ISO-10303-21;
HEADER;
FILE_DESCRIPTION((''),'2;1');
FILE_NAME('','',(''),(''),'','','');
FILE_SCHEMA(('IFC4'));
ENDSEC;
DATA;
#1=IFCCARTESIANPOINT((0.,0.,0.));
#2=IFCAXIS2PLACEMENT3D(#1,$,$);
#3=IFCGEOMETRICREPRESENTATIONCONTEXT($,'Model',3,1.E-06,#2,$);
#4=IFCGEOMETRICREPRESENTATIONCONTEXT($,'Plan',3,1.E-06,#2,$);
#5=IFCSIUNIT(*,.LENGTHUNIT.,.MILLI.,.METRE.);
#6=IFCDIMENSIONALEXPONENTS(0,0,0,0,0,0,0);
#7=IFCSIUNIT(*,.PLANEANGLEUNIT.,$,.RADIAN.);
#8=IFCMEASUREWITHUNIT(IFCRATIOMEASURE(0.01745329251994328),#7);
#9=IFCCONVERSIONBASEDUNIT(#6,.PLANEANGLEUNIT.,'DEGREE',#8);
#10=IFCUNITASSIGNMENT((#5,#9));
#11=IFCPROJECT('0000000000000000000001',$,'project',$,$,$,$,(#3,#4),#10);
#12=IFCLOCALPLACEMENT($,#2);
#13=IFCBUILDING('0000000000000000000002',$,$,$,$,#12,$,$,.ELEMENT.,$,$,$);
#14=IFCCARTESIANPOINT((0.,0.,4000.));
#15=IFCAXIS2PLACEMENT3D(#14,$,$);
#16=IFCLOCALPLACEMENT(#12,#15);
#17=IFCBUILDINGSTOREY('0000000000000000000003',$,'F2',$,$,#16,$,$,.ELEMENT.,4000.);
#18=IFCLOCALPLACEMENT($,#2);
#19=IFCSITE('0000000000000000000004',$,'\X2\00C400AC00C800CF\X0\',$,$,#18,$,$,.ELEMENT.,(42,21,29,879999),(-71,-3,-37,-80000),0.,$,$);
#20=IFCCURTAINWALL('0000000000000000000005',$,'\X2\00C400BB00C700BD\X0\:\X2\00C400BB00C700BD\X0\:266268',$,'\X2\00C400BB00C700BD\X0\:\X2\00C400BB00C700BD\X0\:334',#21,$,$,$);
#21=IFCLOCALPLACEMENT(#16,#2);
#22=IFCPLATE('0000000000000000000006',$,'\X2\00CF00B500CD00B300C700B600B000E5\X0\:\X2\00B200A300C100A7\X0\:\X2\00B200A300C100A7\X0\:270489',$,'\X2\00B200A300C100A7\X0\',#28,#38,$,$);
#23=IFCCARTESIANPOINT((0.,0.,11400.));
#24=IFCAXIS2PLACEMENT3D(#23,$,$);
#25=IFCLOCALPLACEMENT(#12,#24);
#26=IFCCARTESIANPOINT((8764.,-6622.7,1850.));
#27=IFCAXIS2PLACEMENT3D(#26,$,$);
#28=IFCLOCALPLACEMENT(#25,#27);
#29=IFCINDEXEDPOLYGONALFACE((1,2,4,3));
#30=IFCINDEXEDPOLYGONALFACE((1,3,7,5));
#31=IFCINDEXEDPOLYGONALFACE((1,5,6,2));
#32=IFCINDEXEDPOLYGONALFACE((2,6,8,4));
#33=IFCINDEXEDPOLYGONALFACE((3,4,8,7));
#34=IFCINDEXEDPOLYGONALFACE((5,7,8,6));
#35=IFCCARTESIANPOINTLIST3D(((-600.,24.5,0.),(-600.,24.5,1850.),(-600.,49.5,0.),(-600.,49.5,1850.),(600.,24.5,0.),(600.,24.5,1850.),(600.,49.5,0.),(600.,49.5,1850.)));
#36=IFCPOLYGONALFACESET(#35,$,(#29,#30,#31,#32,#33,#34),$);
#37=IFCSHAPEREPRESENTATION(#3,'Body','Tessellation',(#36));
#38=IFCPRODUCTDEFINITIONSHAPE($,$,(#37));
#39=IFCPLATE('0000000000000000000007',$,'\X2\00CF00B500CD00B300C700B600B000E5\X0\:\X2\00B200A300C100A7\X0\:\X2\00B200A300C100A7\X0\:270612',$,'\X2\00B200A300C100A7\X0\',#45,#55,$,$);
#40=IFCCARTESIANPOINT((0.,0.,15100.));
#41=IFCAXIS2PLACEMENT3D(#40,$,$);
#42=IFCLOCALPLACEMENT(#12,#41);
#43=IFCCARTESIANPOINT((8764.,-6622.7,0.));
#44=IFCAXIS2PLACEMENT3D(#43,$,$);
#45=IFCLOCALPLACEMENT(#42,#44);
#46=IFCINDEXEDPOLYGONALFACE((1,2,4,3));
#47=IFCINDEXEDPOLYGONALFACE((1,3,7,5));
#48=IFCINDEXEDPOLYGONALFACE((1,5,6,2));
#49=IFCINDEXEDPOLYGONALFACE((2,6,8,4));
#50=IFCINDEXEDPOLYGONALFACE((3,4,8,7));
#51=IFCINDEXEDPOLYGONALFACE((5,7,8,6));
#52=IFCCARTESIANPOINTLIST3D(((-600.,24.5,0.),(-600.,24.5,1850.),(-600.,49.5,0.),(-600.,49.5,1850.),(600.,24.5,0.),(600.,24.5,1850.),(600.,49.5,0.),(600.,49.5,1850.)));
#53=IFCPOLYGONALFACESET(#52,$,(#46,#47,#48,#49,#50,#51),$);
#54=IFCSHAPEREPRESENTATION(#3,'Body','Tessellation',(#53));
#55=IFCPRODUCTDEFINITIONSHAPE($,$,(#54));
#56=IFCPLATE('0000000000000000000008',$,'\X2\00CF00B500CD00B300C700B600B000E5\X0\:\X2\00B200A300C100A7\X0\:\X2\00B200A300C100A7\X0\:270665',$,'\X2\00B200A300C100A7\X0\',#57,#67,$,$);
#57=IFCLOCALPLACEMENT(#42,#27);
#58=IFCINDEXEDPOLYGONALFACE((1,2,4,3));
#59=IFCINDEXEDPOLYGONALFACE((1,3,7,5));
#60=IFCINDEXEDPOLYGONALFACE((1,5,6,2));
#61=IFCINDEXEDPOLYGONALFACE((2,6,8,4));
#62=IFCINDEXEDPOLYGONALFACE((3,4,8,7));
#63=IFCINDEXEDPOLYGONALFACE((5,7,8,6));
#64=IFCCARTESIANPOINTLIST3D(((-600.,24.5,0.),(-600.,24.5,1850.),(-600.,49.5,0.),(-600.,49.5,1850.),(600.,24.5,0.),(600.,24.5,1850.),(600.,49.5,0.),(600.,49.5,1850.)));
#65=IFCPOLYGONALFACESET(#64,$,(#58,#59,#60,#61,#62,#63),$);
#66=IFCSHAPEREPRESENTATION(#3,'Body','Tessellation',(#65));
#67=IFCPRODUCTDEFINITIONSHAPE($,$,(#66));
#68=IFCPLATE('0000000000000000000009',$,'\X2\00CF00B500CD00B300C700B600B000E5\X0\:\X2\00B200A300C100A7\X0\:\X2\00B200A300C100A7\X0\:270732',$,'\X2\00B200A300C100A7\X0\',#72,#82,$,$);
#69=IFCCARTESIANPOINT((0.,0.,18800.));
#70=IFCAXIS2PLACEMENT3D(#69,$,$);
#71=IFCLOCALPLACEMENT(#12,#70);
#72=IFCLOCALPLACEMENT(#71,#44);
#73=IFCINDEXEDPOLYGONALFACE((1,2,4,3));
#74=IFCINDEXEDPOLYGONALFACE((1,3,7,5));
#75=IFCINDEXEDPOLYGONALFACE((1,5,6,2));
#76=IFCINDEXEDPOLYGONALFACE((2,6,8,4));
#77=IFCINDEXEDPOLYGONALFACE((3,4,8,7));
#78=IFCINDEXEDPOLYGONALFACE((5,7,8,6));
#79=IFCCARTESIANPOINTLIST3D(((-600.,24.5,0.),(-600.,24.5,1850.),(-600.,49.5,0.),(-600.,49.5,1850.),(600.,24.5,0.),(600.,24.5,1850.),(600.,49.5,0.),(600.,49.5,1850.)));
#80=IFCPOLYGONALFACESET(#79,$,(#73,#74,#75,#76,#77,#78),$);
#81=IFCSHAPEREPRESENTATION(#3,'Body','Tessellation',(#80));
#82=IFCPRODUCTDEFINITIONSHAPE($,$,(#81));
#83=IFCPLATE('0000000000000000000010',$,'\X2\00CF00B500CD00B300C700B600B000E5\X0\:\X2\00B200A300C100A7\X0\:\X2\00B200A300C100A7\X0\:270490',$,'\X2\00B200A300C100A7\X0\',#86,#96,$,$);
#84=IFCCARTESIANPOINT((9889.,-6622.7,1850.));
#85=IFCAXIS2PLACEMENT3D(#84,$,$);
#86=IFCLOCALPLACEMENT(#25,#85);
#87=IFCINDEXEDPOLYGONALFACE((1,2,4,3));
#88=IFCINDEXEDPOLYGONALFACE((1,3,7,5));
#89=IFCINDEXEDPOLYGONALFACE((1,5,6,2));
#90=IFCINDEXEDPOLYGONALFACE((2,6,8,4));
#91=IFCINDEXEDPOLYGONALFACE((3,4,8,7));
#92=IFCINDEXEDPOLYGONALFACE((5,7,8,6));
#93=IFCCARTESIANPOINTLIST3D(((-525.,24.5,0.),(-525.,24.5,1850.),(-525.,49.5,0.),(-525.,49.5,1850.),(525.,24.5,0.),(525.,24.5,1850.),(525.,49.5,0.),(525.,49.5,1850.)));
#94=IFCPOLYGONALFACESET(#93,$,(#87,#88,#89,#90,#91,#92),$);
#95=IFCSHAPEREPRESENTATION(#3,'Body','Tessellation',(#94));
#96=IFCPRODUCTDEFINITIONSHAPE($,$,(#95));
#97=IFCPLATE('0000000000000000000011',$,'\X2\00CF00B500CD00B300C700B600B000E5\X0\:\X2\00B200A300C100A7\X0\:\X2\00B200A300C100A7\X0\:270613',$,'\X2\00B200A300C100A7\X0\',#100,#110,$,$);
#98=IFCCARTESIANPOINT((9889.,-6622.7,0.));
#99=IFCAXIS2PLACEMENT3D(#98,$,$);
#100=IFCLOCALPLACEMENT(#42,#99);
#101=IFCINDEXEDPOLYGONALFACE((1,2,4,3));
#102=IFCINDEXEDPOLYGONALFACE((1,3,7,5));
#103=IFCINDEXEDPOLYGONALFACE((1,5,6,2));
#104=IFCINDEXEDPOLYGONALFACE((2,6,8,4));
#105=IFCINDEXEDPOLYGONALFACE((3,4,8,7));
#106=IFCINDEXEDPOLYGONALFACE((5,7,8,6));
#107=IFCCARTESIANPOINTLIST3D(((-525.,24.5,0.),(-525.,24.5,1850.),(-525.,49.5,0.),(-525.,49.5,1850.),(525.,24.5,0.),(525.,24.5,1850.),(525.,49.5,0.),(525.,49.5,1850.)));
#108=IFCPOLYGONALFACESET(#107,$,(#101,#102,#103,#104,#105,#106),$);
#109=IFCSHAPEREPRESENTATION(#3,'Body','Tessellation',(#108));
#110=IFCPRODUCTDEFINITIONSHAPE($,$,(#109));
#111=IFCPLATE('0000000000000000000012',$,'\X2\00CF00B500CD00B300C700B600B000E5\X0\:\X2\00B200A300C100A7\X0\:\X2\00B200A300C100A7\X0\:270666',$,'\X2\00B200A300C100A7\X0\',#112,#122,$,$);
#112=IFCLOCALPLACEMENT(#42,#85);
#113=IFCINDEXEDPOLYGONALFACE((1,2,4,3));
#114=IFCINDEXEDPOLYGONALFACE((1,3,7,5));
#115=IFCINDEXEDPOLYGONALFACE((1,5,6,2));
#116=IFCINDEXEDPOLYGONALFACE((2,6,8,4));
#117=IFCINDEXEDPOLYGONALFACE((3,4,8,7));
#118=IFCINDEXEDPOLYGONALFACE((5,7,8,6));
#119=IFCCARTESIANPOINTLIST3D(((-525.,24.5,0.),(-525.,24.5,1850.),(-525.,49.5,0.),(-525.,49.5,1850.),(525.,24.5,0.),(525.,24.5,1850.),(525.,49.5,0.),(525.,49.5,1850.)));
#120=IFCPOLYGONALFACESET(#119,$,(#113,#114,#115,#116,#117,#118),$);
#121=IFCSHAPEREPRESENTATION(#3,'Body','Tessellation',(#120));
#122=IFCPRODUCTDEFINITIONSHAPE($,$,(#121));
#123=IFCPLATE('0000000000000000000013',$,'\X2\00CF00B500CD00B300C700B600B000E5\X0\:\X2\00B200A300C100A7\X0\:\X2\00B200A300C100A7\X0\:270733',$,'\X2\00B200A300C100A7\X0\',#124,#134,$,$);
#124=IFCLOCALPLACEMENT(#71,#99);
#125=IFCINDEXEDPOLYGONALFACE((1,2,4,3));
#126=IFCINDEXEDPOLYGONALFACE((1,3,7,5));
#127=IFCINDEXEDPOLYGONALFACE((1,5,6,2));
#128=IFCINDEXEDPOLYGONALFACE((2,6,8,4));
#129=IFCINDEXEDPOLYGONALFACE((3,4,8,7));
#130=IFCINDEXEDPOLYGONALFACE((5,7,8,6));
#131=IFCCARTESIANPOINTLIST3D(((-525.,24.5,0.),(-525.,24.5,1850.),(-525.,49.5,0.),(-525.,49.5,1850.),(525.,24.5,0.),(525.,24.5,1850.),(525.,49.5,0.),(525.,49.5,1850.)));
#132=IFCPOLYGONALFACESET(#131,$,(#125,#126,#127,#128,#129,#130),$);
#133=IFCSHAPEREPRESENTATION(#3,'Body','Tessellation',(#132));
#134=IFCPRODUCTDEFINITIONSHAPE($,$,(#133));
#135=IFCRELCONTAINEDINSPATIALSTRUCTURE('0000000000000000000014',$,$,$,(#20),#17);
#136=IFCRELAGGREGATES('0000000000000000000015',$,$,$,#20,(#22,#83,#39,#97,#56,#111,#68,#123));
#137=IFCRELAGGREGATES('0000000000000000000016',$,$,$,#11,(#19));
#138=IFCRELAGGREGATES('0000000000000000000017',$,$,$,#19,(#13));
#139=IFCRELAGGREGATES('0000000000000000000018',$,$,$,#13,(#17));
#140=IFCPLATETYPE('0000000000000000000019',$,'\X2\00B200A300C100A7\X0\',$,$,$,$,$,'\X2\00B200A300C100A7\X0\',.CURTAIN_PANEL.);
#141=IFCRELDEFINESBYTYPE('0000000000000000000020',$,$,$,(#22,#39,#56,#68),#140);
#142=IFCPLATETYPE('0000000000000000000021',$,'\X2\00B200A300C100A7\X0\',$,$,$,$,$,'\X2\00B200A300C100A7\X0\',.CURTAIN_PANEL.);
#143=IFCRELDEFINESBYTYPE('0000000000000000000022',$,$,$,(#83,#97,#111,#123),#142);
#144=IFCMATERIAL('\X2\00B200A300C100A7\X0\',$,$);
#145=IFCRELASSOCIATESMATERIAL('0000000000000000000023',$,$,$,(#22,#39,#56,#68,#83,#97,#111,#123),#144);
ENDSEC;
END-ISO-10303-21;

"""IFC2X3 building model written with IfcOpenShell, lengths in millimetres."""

from ifc_helpers import new_model, entity, si_unit, converted_unit, frame, origin, origin_2d_with_axis, place, context, project, spatial, rectangle, extrude, source, transform, mapped, material, type_object, type_shapes, element, aggregate, save


model = new_model("IFC2X3")

# Units and contexts
model_context = context("Model", 3, precision=1e-06, world=origin())
plan_context = context("Plan", 3, precision=1e-06, world=origin())
ifc_project = project(units=[si_unit("LENGTHUNIT", "METRE", prefix="MILLI"), converted_unit("PLANEANGLEUNIT", "DEGREE", entity("IfcRatioMeasure", 0.01745329251994328), si_unit("PLANEANGLEUNIT", "RADIAN"), dimensions=[0, 0, 0, 0, 0, 0, 0])], contexts=[model_context, plan_context])

# Site, building, storey
site_placement = place(None, origin())
site = spatial("IfcSite", under=ifc_project, at=site_placement, Name="Ä¬ÈÏ", CompositionType="ELEMENT", RefLatitude=(42, 21, 29, 879999), RefLongitude=(-71, -3, -37, -80000), RefElevation=0.0)
building_placement = place(None, origin())
building = spatial("IfcBuilding", under=site, at=building_placement, CompositionType="ELEMENT")
storey_placement = place(building_placement, frame((0.0, 0.0, 4000.0)))
storey = spatial("IfcBuildingStorey", under=building, at=storey_placement, Name="F2", CompositionType="ELEMENT", Elevation=4000.0)

# Curtain wall, plates
curtain_wall_placement = place(storey_placement, origin())
curtain_wall = element("IfcCurtainWall", 1, at=curtain_wall_placement, inside=storey, Name="Ä»Ç½:Ä»Ç½:266268", ObjectType="Ä»Ç½:Ä»Ç½:334")
placement_1 = place(building_placement, frame((0.0, 0.0, 15100.0)))
placement_2 = place(building_placement, frame((0.0, 0.0, 11400.0)))
placement_3 = place(building_placement, frame((0.0, 0.0, 18800.0)))
ifc_material_1 = material(Name="²£Á§")
plate_type_1 = type_object("IfcPlateType", Name="²£Á§", ElementType="²£Á§", PredefinedType="CURTAIN_PANEL")
shared_shape_1 = source(origin(), model_context, "Body", "SweptSolid", [
    extrude(rectangle(XDim=25.0, YDim=1200.0, at=origin_2d_with_axis()), frame((0.0, 37.0, 0.0), z_axis=(0.0, 0.0, 1.0), x_axis=(0.0, 1.0, 0.0)), (0.0, 0.0, 1.0), 1850.0),
])
type_shapes(plate_type_1, [shared_shape_1])
plate_1_placement = place(placement_2, frame((8764.0, -6622.7, 1850.0)))
plate_1 = element("IfcPlate", 2, at=plate_1_placement, type_object=plate_type_1, material=ifc_material_1, Name="ÏµÍ³Ç¶°å:²£Á§:²£Á§:270489", ObjectType="²£Á§", context=model_context, shape_type="MappedRepresentation", body=[
    mapped(shared_shape_1, transform((0.0, 0.0, 0.0), scale=1.0)),
])
plate_2_placement = place(placement_1, frame((8764.0, -6622.7, 0.0)))
plate_2 = element("IfcPlate", 3, at=plate_2_placement, type_object=plate_type_1, material=ifc_material_1, Name="ÏµÍ³Ç¶°å:²£Á§:²£Á§:270612", ObjectType="²£Á§", context=model_context, shape_type="MappedRepresentation", body=[
    mapped(shared_shape_1, transform((0.0, 0.0, 0.0), scale=1.0)),
])
plate_3_placement = place(placement_1, frame((8764.0, -6622.7, 1850.0)))
plate_3 = element("IfcPlate", 4, at=plate_3_placement, type_object=plate_type_1, material=ifc_material_1, Name="ÏµÍ³Ç¶°å:²£Á§:²£Á§:270665", ObjectType="²£Á§", context=model_context, shape_type="MappedRepresentation", body=[
    mapped(shared_shape_1, transform((0.0, 0.0, 0.0), scale=1.0)),
])
plate_4_placement = place(placement_3, frame((8764.0, -6622.7, 0.0)))
plate_4 = element("IfcPlate", 5, at=plate_4_placement, type_object=plate_type_1, material=ifc_material_1, Name="ÏµÍ³Ç¶°å:²£Á§:²£Á§:270732", ObjectType="²£Á§", context=model_context, shape_type="MappedRepresentation", body=[
    mapped(shared_shape_1, transform((0.0, 0.0, 0.0), scale=1.0)),
])
plate_type_2 = type_object("IfcPlateType", Name="²£Á§", ElementType="²£Á§", PredefinedType="CURTAIN_PANEL")
shared_shape_2 = source(origin(), model_context, "Body", "SweptSolid", [
    extrude(rectangle(XDim=25.0, YDim=1050.0, at=origin_2d_with_axis()), frame((0.0, 37.0, 0.0), z_axis=(0.0, 0.0, 1.0), x_axis=(0.0, 1.0, 0.0)), (0.0, 0.0, 1.0), 1850.0),
])
type_shapes(plate_type_2, [shared_shape_2])
plate_5_placement = place(placement_2, frame((9889.0, -6622.7, 1850.0)))
plate_5 = element("IfcPlate", 6, at=plate_5_placement, type_object=plate_type_2, material=ifc_material_1, Name="ÏµÍ³Ç¶°å:²£Á§:²£Á§:270490", ObjectType="²£Á§", context=model_context, shape_type="MappedRepresentation", body=[
    mapped(shared_shape_2, transform((0.0, 0.0, 0.0), scale=1.0)),
])
plate_6_placement = place(placement_1, frame((9889.0, -6622.7, 0.0)))
plate_6 = element("IfcPlate", 7, at=plate_6_placement, type_object=plate_type_2, material=ifc_material_1, Name="ÏµÍ³Ç¶°å:²£Á§:²£Á§:270613", ObjectType="²£Á§", context=model_context, shape_type="MappedRepresentation", body=[
    mapped(shared_shape_2, transform((0.0, 0.0, 0.0), scale=1.0)),
])
plate_7_placement = place(placement_1, frame((9889.0, -6622.7, 1850.0)))
plate_7 = element("IfcPlate", 8, at=plate_7_placement, type_object=plate_type_2, material=ifc_material_1, Name="ÏµÍ³Ç¶°å:²£Á§:²£Á§:270666", ObjectType="²£Á§", context=model_context, shape_type="MappedRepresentation", body=[
    mapped(shared_shape_2, transform((0.0, 0.0, 0.0), scale=1.0)),
])
plate_8_placement = place(placement_3, frame((9889.0, -6622.7, 0.0)))
plate_8 = element("IfcPlate", 9, at=plate_8_placement, type_object=plate_type_2, material=ifc_material_1, Name="ÏµÍ³Ç¶°å:²£Á§:²£Á§:270733", ObjectType="²£Á§", context=model_context, shape_type="MappedRepresentation", body=[
    mapped(shared_shape_2, transform((0.0, 0.0, 0.0), scale=1.0)),
])
aggregate(curtain_wall, [plate_1, plate_5, plate_2, plate_6, plate_3, plate_7, plate_4, plate_8])

save(model, "model.ifc")
